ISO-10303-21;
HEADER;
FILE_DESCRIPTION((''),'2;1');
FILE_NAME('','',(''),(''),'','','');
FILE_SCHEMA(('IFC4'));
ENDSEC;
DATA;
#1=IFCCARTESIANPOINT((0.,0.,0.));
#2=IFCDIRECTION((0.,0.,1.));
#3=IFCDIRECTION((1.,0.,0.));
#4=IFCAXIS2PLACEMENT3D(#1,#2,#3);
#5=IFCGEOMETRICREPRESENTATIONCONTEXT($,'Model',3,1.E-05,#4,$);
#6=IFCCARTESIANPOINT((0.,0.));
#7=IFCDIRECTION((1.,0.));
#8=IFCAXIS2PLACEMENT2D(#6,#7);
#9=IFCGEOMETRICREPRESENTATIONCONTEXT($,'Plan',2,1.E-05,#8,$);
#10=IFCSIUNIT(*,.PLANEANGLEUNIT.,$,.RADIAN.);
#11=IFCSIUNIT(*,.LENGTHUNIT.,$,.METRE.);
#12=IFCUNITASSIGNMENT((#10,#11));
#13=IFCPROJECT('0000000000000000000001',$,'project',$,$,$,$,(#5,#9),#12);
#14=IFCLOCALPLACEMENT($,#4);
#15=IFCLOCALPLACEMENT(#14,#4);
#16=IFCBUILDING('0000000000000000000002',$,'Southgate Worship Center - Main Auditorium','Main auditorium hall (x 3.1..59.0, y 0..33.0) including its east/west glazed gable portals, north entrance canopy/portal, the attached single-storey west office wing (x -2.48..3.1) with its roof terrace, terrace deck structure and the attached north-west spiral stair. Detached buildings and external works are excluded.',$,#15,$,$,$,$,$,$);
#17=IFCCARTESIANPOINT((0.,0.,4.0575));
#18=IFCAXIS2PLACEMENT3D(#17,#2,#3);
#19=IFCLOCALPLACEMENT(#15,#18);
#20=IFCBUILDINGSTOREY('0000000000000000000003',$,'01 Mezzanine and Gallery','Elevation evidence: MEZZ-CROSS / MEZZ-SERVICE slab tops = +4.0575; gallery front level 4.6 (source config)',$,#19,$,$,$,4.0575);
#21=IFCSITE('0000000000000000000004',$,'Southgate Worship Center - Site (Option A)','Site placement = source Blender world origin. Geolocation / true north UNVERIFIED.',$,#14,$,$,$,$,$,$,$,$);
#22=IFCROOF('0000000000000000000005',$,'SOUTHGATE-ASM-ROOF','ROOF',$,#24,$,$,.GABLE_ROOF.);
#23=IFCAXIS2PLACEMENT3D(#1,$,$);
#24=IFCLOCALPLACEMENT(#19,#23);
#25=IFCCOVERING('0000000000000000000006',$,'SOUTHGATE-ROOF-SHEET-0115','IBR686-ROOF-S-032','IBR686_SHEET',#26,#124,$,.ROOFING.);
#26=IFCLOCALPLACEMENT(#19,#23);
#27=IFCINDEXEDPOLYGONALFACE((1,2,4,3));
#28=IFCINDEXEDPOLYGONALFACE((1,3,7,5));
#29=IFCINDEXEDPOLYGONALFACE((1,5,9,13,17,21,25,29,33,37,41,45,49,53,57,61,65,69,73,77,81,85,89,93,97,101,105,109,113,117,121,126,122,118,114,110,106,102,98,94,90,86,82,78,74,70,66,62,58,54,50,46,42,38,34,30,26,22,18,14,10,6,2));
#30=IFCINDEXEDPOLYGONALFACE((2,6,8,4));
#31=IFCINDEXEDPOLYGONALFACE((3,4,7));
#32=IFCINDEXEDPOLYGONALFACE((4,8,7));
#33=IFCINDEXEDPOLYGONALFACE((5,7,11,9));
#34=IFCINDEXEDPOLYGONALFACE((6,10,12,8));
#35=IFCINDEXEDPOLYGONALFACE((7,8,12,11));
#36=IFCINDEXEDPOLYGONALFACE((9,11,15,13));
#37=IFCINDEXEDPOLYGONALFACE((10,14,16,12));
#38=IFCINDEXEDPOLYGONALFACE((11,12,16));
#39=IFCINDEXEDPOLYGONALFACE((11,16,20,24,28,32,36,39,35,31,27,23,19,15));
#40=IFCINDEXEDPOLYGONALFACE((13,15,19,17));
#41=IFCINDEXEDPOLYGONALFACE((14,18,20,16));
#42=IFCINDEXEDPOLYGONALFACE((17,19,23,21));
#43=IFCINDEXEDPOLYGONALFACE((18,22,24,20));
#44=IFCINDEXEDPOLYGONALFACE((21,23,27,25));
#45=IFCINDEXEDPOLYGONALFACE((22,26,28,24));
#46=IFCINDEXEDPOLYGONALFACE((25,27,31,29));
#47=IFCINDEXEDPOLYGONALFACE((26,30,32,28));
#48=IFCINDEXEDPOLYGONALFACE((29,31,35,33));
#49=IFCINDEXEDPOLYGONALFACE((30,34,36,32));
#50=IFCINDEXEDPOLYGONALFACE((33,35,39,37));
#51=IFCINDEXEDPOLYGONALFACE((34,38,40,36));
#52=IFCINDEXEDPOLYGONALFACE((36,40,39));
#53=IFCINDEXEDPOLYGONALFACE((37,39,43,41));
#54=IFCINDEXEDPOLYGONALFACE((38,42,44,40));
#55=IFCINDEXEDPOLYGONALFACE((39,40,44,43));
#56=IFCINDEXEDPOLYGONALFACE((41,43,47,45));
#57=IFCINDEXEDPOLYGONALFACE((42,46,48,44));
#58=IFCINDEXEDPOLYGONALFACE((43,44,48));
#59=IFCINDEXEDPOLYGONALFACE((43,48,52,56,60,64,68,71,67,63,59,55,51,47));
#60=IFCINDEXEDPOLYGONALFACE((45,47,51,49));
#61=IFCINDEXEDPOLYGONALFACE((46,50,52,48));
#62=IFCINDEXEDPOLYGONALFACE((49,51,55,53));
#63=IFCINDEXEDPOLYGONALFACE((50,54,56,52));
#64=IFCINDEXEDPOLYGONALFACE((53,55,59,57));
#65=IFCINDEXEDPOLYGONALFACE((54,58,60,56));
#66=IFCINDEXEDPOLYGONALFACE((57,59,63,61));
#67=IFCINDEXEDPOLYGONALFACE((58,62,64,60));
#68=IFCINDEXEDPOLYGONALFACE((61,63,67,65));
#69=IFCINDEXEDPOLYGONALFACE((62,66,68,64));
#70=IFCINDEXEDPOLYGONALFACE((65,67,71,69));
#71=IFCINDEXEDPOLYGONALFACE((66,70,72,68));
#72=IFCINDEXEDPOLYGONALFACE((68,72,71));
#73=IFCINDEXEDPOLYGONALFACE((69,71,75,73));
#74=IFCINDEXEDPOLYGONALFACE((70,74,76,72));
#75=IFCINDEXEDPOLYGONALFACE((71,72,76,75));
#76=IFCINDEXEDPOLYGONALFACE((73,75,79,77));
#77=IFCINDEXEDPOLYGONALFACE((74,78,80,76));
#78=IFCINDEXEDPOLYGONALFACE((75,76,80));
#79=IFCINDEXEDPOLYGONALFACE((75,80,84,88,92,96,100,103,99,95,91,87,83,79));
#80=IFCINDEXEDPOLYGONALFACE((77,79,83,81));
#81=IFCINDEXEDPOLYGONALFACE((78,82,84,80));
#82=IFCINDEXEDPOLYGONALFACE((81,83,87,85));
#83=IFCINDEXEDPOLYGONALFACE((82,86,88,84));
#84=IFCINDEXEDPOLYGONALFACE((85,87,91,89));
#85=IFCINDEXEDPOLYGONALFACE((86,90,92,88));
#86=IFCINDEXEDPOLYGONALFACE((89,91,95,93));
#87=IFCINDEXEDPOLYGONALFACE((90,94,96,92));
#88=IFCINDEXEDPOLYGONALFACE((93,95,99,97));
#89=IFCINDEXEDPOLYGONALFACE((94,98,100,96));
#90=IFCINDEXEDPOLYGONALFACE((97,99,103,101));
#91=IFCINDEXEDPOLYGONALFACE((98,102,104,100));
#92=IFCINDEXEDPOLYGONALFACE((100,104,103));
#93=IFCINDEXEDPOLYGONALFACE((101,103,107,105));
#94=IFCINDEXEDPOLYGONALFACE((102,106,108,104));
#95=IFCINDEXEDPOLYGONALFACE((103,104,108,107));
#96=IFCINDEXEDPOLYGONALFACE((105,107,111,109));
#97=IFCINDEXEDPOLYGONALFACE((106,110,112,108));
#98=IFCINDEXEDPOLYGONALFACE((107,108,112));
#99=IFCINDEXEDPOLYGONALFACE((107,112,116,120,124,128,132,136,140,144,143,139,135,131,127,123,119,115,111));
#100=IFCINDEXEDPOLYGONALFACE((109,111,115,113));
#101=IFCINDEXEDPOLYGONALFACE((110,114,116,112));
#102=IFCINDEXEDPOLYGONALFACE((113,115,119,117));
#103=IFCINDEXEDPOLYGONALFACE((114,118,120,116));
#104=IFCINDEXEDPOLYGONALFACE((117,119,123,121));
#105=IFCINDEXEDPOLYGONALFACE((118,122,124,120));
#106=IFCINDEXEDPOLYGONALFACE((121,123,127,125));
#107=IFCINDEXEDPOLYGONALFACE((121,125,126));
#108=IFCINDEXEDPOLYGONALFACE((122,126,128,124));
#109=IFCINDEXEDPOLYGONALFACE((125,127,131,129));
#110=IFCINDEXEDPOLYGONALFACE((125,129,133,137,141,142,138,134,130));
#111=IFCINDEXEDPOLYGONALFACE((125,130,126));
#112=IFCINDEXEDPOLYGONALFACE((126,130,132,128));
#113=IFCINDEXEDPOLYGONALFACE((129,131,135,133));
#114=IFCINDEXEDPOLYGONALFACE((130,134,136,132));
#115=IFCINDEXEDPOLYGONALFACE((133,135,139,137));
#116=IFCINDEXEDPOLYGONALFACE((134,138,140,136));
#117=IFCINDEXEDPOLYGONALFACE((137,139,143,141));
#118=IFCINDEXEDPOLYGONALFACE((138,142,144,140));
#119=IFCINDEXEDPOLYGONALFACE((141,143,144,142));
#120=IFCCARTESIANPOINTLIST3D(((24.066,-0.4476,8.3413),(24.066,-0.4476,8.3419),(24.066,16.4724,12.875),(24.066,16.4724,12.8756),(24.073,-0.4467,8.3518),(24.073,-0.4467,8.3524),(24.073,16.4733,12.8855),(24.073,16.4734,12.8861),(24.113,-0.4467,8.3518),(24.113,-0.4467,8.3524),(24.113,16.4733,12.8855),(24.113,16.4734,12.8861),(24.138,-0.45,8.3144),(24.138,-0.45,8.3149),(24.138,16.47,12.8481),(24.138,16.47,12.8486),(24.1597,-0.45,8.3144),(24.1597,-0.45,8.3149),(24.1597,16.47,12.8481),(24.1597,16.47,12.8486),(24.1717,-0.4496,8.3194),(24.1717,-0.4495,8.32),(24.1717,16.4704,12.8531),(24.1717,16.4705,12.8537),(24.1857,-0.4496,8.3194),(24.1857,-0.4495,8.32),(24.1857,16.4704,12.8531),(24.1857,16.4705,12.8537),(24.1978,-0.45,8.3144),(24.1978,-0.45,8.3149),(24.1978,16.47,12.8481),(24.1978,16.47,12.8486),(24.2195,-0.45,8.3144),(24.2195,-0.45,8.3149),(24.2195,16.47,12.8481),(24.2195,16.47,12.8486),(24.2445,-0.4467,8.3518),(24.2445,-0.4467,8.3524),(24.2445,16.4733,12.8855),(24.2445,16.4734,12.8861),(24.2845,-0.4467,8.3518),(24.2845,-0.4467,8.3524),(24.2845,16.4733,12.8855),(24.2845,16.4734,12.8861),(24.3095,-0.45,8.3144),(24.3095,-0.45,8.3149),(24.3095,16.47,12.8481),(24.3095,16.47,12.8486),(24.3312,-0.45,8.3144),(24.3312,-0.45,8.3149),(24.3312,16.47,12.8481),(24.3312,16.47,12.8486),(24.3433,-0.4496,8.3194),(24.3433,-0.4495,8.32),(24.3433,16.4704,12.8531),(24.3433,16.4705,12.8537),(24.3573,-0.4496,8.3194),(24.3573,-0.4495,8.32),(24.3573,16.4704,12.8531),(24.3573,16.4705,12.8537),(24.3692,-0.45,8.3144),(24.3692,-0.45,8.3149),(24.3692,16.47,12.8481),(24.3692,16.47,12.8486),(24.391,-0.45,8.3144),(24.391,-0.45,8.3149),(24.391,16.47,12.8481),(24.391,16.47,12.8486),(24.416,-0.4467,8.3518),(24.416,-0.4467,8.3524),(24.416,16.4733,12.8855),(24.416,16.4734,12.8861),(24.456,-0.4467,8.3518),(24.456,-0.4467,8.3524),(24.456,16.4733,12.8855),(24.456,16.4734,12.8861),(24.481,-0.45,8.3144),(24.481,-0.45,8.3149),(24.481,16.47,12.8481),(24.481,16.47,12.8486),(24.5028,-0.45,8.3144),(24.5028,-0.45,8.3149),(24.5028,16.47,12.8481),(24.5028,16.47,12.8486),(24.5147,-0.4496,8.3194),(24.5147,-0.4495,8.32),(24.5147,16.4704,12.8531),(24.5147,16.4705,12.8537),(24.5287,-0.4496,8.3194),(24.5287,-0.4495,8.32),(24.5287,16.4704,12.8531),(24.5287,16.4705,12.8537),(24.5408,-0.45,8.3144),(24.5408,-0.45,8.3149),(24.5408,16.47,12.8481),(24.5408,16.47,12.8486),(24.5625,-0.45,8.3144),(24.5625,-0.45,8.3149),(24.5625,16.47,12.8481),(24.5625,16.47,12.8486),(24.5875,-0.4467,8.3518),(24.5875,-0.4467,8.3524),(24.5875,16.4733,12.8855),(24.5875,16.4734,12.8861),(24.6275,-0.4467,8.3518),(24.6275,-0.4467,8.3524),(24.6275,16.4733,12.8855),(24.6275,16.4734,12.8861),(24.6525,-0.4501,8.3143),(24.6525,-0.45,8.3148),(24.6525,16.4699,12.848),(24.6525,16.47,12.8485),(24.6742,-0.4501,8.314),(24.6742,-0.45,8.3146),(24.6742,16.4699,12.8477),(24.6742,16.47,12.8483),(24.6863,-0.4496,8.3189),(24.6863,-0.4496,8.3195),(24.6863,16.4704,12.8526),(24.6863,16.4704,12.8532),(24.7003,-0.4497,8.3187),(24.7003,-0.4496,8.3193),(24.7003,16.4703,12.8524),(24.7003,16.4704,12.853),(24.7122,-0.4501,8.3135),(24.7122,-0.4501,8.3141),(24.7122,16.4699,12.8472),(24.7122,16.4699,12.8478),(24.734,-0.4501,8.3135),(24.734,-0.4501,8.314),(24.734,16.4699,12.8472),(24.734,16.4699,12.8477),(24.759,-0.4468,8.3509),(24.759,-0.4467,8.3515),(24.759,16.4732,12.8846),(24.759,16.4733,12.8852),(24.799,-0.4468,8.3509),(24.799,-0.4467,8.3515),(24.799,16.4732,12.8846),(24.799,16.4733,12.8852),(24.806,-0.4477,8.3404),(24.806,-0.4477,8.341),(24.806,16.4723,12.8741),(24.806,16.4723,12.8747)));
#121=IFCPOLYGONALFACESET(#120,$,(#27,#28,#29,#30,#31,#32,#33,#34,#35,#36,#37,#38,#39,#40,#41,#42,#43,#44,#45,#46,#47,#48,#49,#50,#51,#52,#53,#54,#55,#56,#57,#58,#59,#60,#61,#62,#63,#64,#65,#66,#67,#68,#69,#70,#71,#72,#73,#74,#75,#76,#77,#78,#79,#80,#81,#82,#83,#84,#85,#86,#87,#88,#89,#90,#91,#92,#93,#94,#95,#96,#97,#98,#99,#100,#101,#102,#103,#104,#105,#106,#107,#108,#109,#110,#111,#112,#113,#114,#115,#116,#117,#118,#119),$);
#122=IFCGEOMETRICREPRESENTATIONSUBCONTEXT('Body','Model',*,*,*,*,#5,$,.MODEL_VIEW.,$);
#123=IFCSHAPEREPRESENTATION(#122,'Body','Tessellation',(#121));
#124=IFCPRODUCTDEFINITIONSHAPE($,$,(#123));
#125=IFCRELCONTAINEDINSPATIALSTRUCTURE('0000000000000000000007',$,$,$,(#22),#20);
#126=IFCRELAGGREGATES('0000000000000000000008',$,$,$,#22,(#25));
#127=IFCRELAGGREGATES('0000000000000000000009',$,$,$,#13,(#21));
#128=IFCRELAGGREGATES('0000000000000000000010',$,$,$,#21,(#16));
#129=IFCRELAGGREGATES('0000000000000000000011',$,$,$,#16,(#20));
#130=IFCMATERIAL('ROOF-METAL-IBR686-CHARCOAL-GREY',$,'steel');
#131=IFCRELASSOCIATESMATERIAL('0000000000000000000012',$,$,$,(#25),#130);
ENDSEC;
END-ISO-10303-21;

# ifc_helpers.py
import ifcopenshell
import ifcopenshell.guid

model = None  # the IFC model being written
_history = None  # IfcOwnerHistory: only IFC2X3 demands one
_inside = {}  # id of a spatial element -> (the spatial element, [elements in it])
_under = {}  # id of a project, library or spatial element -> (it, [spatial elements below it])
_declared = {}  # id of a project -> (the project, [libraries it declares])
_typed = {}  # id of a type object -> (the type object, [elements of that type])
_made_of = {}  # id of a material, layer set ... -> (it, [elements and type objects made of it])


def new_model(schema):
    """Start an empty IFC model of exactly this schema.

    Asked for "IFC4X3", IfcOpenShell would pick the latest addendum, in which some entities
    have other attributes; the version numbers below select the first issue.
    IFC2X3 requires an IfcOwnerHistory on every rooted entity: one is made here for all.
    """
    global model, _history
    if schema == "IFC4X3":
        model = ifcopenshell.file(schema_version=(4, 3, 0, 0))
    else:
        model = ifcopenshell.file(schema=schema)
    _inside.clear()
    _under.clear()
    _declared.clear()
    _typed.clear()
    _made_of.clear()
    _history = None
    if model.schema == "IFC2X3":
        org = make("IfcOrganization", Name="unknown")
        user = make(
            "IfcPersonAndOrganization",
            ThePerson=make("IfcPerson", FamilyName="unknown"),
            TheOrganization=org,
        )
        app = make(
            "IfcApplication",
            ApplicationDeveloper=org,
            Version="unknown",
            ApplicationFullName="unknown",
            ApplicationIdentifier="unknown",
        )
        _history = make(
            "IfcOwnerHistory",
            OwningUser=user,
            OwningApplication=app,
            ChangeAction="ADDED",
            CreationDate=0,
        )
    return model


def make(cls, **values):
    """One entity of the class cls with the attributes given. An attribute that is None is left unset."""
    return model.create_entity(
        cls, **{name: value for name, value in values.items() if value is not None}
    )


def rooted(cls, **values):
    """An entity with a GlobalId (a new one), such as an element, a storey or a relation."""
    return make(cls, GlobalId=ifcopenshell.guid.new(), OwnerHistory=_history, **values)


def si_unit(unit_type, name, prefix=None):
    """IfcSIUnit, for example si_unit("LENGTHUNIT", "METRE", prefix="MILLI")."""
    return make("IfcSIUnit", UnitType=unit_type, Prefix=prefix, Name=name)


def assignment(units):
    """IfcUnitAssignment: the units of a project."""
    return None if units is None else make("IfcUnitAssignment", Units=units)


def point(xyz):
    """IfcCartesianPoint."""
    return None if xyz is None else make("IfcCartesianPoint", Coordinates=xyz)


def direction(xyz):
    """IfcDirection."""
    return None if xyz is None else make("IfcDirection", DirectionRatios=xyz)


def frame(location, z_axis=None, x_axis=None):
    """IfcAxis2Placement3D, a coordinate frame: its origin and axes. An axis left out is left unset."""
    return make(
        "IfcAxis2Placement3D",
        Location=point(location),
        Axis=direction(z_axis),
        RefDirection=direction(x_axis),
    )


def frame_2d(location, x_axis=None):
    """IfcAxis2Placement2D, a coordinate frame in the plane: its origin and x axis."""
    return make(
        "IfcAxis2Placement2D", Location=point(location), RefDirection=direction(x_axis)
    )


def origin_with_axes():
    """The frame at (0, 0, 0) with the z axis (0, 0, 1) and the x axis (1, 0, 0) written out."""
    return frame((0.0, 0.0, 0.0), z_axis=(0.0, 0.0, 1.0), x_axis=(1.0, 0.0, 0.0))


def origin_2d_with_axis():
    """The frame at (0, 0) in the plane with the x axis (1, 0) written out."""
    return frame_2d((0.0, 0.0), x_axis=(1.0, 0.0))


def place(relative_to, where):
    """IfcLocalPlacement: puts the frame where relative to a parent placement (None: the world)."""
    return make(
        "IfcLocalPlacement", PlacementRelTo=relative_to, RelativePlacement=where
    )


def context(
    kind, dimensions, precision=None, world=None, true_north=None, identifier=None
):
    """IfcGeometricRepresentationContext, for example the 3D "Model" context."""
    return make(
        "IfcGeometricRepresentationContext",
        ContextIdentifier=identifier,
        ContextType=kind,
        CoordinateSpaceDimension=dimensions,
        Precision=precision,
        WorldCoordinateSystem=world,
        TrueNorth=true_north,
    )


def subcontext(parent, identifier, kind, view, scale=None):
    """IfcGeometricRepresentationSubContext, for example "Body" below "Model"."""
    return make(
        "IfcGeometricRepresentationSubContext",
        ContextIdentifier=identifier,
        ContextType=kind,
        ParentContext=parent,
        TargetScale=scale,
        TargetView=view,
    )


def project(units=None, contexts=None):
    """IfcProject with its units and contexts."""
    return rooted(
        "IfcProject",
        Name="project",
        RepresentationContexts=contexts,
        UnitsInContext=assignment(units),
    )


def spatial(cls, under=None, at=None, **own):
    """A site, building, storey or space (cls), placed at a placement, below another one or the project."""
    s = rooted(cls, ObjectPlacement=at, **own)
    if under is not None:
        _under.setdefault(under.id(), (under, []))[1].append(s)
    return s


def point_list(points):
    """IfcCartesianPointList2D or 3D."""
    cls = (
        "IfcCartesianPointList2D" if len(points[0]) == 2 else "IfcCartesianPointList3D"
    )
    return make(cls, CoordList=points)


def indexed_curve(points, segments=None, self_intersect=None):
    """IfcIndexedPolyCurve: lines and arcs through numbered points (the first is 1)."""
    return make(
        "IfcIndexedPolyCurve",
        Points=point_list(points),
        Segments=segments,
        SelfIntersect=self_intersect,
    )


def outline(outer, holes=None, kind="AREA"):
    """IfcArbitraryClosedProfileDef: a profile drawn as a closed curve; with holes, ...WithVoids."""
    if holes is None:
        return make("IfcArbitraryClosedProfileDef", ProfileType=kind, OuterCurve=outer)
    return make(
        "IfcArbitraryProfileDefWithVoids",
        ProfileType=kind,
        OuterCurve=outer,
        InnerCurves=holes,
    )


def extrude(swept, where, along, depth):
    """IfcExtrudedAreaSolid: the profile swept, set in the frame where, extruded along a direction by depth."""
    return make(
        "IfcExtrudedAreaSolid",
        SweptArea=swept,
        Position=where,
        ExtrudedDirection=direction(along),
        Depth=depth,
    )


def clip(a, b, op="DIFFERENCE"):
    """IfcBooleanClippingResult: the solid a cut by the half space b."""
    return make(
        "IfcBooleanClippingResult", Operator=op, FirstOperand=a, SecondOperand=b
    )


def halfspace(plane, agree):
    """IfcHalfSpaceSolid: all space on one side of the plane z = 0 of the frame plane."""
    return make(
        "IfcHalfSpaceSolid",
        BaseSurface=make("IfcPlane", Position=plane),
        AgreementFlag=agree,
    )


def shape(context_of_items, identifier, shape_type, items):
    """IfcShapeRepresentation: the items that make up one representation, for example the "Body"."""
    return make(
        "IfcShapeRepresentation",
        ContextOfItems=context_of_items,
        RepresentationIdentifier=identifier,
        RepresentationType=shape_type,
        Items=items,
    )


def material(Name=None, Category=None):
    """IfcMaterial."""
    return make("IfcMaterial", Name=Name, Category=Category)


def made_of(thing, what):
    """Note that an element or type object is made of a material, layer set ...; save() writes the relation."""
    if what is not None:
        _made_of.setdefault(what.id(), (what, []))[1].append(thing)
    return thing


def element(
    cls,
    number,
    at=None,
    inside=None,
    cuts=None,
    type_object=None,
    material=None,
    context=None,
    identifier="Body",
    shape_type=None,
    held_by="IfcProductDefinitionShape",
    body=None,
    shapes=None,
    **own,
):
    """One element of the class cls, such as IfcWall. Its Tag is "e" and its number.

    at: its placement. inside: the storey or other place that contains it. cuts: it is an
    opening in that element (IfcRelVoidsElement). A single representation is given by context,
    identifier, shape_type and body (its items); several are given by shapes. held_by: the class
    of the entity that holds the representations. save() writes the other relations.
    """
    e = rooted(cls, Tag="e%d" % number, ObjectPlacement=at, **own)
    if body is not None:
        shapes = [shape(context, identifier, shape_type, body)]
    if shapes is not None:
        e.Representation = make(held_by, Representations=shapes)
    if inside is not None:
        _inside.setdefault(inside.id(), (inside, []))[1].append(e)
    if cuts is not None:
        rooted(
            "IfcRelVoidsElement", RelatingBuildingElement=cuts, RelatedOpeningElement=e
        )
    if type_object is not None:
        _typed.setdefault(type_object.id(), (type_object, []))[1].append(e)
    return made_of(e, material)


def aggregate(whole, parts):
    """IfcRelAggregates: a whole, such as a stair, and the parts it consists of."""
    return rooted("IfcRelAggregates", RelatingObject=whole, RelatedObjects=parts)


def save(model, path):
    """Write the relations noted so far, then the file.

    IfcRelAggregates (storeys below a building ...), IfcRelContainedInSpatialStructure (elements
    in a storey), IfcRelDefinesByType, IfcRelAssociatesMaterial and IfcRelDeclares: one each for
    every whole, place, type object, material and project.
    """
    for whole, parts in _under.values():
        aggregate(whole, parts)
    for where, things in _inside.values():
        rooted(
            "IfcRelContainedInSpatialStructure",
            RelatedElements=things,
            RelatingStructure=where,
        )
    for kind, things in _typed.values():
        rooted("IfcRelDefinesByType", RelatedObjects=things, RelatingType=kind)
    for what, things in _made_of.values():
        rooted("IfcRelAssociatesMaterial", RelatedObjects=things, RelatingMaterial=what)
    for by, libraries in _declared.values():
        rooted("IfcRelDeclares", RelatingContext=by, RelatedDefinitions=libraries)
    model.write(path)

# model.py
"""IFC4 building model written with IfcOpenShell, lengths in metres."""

from ifc_helpers import new_model, si_unit, frame, origin_with_axes, origin_2d_with_axis, place, context, subcontext, project, spatial, indexed_curve, outline, extrude, clip, halfspace, material, element, aggregate, save


model = new_model("IFC4")

# Units and contexts
model_context = context("Model", 3, precision=1e-05, world=origin_with_axes())
plan_context = context("Plan", 2, precision=1e-05, world=origin_2d_with_axis())
body_context = subcontext(model_context, "Body", "Model", "MODEL_VIEW")
ifc_project = project(units=[si_unit("PLANEANGLEUNIT", "RADIAN"), si_unit("LENGTHUNIT", "METRE")], contexts=[model_context, plan_context])

# Site, building, storey
site_placement = place(None, origin_with_axes())
site = spatial("IfcSite", under=ifc_project, at=site_placement, Name="Southgate Worship Center - Site (Option A)", Description="Site placement = source Blender world origin. Geolocation / true north UNVERIFIED.")
building_placement = place(site_placement, origin_with_axes())
building = spatial("IfcBuilding", under=site, at=building_placement, Name="Southgate Worship Center - Main Auditorium", Description="Main auditorium hall (x 3.1..59.0, y 0..33.0) including its east/west glazed gable portals, north entrance canopy/portal, the attached single-storey west office wing (x -2.48..3.1) with its roof terrace, terrace deck structure and the attached north-west spiral stair. Detached buildings and external works are excluded.")
storey_placement = place(building_placement, frame((0.0, 0.0, 4.0575), z_axis=(0.0, 0.0, 1.0), x_axis=(1.0, 0.0, 0.0)))
storey = spatial("IfcBuildingStorey", under=building, at=storey_placement, Name="01 Mezzanine and Gallery", Description="Elevation evidence: MEZZ-CROSS / MEZZ-SERVICE slab tops = +4.0575; gallery front level 4.6 (source config)", Elevation=4.0575)

# Roof, covering
roof_placement = place(storey_placement, origin_with_axes())
roof = element("IfcRoof", 1, at=roof_placement, inside=storey, Name="SOUTHGATE-ASM-ROOF", Description="ROOF", PredefinedType="GABLE_ROOF")
ifc_material_1 = material(Name="ROOF-METAL-IBR686-CHARCOAL-GREY", Category="steel")
covering_1_placement = place(roof_placement, frame((24.066, -0.4501, 8.3135), z_axis=(0.0, 0.0, 1.0), x_axis=(1.0, 0.0, 0.0)))
covering_1 = element("IfcCovering", 2, at=covering_1_placement, material=ifc_material_1, Name="SOUTHGATE-ROOF-SHEET-0115", Description="IBR686-ROOF-S-032", ObjectType="IBR686_SHEET", PredefinedType="ROOFING", context=body_context, shape_type="Clipping", body=[
    clip(clip(extrude(outline(indexed_curve([(0.0, 0.0), (0.025, 0.0353), (0.065, 0.0353), (0.072, 0.0254), (0.072, 0.0259), (0.065, 0.0358), (0.025, 0.0358), (0.0, 0.0005), (-0.0217, 0.0005), (-0.0337, 0.0053), (-0.0477, 0.0053), (-0.0597, 0.0005), (-0.0815, 0.0005), (-0.1065, 0.0358), (-0.1465, 0.0358), (-0.1715, 0.0005), (-0.1932, 0.0005), (-0.2052, 0.0053), (-0.2192, 0.0053), (-0.2312, 0.0005), (-0.253, 0.0005), (-0.278, 0.0358), (-0.318, 0.0358), (-0.343, 0.0005), (-0.3647, 0.0005), (-0.3767, 0.0053), (-0.3907, 0.0053), (-0.4028, 0.0005), (-0.4245, 0.0005), (-0.4495, 0.0358), (-0.4895, 0.0358), (-0.5145, 0.0004), (-0.5362, 0.0002), (-0.5483, 0.0048), (-0.5623, 0.0046), (-0.5742, -0.0003), (-0.596, -0.0004), (-0.621, 0.0349), (-0.661, 0.0349), (-0.668, 0.0251), (-0.668, 0.0246), (-0.661, 0.0344), (-0.621, 0.0344), (-0.596, -0.0009), (-0.5742, -0.0008), (-0.5623, 0.0041), (-0.5483, 0.0043), (-0.5362, -0.0003), (-0.5145, -0.0001), (-0.4895, 0.0353), (-0.4495, 0.0353), (-0.4245, 0.0), (-0.4028, 0.0), (-0.3907, 0.0048), (-0.3767, 0.0048), (-0.3647, 0.0), (-0.343, 0.0), (-0.318, 0.0353), (-0.278, 0.0353), (-0.253, 0.0), (-0.2312, 0.0), (-0.2192, 0.0048), (-0.2052, 0.0048), (-0.1932, 0.0), (-0.1715, 0.0), (-0.1465, 0.0353), (-0.1065, 0.0353), (-0.0815, 0.0), (-0.0597, 0.0), (-0.0477, 0.0048), (-0.0337, 0.0048), (-0.0217, 0.0), (0.0, 0.0)], self_intersect=False)), frame((0.072, -0.0003, 0.0008), z_axis=(0.0, 0.965926, 0.258819), x_axis=(-1.0, 0.0, 0.0)), (0.0, 0.0, 1.0), 17.5303), halfspace(frame((0.37, 0.0012, 0.014), z_axis=(0.0, -0.996022, 0.089113), x_axis=(1.0, 0.0, 0.0)), False)), halfspace(frame((0.37, 16.9212, 4.5477), z_axis=(0.0, 0.996021, -0.089119), x_axis=(-1.0, 0.0, 0.0)), False)),
])
aggregate(roof, [covering_1])

save(model, "model.ifc")
